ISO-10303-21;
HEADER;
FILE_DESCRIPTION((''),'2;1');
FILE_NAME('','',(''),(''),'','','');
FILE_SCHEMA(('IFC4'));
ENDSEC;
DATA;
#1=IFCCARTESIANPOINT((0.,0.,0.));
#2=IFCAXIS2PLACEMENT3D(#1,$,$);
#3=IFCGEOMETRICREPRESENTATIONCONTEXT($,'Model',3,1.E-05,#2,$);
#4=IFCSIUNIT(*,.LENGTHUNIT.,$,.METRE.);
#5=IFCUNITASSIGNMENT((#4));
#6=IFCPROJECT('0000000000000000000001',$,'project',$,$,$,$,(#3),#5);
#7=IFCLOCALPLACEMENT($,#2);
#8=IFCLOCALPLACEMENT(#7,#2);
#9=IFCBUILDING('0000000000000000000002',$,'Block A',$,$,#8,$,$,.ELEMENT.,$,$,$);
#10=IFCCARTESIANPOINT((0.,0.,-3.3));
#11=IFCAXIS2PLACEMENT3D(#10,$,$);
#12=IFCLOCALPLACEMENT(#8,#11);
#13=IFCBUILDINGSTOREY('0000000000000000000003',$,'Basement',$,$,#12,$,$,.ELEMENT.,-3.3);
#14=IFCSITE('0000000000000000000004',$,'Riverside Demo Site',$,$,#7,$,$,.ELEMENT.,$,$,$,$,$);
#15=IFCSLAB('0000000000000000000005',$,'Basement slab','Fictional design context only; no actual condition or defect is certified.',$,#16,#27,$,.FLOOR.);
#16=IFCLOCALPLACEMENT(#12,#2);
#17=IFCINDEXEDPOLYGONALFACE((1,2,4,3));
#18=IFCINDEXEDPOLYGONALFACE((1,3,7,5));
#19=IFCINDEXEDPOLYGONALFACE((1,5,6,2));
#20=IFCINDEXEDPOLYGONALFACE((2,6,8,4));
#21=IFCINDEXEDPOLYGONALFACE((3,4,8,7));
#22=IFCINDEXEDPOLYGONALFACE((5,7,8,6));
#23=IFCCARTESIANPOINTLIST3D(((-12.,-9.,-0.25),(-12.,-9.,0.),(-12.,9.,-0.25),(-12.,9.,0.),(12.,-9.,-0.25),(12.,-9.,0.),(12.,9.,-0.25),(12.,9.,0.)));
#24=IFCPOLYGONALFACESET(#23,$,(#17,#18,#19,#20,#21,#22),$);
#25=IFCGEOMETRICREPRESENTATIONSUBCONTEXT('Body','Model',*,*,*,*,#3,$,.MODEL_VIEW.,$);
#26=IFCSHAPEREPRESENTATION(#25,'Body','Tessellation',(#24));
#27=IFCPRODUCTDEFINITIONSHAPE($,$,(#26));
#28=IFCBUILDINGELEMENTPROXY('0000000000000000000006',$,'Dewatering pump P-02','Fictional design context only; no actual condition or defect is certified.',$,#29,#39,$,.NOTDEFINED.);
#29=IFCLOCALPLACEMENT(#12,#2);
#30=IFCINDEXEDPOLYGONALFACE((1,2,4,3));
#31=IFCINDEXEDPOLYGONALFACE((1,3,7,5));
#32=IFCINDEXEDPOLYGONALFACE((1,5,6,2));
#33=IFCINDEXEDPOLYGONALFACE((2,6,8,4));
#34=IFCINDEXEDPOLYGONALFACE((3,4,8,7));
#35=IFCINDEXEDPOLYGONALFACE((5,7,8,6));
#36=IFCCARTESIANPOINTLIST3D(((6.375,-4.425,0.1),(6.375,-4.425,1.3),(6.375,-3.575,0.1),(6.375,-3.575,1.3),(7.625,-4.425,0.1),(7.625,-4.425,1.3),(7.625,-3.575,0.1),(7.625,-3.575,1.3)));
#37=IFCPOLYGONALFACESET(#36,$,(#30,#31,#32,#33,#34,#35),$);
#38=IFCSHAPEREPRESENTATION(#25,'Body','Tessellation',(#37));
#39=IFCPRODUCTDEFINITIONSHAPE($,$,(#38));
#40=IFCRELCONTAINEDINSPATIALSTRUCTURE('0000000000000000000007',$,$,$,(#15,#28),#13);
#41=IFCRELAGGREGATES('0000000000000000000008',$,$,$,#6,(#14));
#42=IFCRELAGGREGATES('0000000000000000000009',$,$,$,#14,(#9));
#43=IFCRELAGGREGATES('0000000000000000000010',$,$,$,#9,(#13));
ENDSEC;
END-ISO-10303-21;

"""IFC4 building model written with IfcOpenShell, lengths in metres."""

from ifc_helpers import new_model, si_unit, frame, origin, origin_2d, place, context, subcontext, project, spatial, rectangle, extrude, element, save


model = new_model("IFC4")

# Units and contexts
model_context = context("Model", 3, precision=1e-05, world=origin())
body_context = subcontext(model_context, "Body", "Model", "MODEL_VIEW")
ifc_project = project(units=[si_unit("LENGTHUNIT", "METRE")], contexts=[model_context])

# Site, building, storey
site_placement = place(None, origin())
site = spatial("IfcSite", under=ifc_project, at=site_placement, Name="Riverside Demo Site", CompositionType="ELEMENT")
building_placement = place(site_placement, origin())
building = spatial("IfcBuilding", under=site, at=building_placement, Name="Block A", CompositionType="ELEMENT")
storey_placement = place(building_placement, frame((0.0, 0.0, -3.3)))
storey = spatial("IfcBuildingStorey", under=building, at=storey_placement, Name="Basement", CompositionType="ELEMENT", Elevation=-3.3)

# Slab
slab_placement = place(storey_placement, frame((0.0, 0.0, -0.25)))
element("IfcSlab", 1, at=slab_placement, inside=storey, Name="Basement slab", Description="Fictional design context only; no actual condition or defect is certified.", PredefinedType="FLOOR", context=body_context, shape_type="SweptSolid", body=[
    extrude(rectangle(XDim=24.0, YDim=18.0, at=origin_2d()), origin(), (0.0, 0.0, 1.0), 0.25),
])

# Building element proxy
proxy_placement = place(storey_placement, frame((7.0, -4.0, 0.1)))
element("IfcBuildingElementProxy", 2, at=proxy_placement, inside=storey, Name="Dewatering pump P-02", Description="Fictional design context only; no actual condition or defect is certified.", PredefinedType="NOTDEFINED", context=body_context, shape_type="SweptSolid", body=[
    extrude(rectangle(XDim=1.25, YDim=0.85, at=origin_2d()), origin(), (0.0, 0.0, 1.0), 1.2),
])

save(model, "model.ifc")
